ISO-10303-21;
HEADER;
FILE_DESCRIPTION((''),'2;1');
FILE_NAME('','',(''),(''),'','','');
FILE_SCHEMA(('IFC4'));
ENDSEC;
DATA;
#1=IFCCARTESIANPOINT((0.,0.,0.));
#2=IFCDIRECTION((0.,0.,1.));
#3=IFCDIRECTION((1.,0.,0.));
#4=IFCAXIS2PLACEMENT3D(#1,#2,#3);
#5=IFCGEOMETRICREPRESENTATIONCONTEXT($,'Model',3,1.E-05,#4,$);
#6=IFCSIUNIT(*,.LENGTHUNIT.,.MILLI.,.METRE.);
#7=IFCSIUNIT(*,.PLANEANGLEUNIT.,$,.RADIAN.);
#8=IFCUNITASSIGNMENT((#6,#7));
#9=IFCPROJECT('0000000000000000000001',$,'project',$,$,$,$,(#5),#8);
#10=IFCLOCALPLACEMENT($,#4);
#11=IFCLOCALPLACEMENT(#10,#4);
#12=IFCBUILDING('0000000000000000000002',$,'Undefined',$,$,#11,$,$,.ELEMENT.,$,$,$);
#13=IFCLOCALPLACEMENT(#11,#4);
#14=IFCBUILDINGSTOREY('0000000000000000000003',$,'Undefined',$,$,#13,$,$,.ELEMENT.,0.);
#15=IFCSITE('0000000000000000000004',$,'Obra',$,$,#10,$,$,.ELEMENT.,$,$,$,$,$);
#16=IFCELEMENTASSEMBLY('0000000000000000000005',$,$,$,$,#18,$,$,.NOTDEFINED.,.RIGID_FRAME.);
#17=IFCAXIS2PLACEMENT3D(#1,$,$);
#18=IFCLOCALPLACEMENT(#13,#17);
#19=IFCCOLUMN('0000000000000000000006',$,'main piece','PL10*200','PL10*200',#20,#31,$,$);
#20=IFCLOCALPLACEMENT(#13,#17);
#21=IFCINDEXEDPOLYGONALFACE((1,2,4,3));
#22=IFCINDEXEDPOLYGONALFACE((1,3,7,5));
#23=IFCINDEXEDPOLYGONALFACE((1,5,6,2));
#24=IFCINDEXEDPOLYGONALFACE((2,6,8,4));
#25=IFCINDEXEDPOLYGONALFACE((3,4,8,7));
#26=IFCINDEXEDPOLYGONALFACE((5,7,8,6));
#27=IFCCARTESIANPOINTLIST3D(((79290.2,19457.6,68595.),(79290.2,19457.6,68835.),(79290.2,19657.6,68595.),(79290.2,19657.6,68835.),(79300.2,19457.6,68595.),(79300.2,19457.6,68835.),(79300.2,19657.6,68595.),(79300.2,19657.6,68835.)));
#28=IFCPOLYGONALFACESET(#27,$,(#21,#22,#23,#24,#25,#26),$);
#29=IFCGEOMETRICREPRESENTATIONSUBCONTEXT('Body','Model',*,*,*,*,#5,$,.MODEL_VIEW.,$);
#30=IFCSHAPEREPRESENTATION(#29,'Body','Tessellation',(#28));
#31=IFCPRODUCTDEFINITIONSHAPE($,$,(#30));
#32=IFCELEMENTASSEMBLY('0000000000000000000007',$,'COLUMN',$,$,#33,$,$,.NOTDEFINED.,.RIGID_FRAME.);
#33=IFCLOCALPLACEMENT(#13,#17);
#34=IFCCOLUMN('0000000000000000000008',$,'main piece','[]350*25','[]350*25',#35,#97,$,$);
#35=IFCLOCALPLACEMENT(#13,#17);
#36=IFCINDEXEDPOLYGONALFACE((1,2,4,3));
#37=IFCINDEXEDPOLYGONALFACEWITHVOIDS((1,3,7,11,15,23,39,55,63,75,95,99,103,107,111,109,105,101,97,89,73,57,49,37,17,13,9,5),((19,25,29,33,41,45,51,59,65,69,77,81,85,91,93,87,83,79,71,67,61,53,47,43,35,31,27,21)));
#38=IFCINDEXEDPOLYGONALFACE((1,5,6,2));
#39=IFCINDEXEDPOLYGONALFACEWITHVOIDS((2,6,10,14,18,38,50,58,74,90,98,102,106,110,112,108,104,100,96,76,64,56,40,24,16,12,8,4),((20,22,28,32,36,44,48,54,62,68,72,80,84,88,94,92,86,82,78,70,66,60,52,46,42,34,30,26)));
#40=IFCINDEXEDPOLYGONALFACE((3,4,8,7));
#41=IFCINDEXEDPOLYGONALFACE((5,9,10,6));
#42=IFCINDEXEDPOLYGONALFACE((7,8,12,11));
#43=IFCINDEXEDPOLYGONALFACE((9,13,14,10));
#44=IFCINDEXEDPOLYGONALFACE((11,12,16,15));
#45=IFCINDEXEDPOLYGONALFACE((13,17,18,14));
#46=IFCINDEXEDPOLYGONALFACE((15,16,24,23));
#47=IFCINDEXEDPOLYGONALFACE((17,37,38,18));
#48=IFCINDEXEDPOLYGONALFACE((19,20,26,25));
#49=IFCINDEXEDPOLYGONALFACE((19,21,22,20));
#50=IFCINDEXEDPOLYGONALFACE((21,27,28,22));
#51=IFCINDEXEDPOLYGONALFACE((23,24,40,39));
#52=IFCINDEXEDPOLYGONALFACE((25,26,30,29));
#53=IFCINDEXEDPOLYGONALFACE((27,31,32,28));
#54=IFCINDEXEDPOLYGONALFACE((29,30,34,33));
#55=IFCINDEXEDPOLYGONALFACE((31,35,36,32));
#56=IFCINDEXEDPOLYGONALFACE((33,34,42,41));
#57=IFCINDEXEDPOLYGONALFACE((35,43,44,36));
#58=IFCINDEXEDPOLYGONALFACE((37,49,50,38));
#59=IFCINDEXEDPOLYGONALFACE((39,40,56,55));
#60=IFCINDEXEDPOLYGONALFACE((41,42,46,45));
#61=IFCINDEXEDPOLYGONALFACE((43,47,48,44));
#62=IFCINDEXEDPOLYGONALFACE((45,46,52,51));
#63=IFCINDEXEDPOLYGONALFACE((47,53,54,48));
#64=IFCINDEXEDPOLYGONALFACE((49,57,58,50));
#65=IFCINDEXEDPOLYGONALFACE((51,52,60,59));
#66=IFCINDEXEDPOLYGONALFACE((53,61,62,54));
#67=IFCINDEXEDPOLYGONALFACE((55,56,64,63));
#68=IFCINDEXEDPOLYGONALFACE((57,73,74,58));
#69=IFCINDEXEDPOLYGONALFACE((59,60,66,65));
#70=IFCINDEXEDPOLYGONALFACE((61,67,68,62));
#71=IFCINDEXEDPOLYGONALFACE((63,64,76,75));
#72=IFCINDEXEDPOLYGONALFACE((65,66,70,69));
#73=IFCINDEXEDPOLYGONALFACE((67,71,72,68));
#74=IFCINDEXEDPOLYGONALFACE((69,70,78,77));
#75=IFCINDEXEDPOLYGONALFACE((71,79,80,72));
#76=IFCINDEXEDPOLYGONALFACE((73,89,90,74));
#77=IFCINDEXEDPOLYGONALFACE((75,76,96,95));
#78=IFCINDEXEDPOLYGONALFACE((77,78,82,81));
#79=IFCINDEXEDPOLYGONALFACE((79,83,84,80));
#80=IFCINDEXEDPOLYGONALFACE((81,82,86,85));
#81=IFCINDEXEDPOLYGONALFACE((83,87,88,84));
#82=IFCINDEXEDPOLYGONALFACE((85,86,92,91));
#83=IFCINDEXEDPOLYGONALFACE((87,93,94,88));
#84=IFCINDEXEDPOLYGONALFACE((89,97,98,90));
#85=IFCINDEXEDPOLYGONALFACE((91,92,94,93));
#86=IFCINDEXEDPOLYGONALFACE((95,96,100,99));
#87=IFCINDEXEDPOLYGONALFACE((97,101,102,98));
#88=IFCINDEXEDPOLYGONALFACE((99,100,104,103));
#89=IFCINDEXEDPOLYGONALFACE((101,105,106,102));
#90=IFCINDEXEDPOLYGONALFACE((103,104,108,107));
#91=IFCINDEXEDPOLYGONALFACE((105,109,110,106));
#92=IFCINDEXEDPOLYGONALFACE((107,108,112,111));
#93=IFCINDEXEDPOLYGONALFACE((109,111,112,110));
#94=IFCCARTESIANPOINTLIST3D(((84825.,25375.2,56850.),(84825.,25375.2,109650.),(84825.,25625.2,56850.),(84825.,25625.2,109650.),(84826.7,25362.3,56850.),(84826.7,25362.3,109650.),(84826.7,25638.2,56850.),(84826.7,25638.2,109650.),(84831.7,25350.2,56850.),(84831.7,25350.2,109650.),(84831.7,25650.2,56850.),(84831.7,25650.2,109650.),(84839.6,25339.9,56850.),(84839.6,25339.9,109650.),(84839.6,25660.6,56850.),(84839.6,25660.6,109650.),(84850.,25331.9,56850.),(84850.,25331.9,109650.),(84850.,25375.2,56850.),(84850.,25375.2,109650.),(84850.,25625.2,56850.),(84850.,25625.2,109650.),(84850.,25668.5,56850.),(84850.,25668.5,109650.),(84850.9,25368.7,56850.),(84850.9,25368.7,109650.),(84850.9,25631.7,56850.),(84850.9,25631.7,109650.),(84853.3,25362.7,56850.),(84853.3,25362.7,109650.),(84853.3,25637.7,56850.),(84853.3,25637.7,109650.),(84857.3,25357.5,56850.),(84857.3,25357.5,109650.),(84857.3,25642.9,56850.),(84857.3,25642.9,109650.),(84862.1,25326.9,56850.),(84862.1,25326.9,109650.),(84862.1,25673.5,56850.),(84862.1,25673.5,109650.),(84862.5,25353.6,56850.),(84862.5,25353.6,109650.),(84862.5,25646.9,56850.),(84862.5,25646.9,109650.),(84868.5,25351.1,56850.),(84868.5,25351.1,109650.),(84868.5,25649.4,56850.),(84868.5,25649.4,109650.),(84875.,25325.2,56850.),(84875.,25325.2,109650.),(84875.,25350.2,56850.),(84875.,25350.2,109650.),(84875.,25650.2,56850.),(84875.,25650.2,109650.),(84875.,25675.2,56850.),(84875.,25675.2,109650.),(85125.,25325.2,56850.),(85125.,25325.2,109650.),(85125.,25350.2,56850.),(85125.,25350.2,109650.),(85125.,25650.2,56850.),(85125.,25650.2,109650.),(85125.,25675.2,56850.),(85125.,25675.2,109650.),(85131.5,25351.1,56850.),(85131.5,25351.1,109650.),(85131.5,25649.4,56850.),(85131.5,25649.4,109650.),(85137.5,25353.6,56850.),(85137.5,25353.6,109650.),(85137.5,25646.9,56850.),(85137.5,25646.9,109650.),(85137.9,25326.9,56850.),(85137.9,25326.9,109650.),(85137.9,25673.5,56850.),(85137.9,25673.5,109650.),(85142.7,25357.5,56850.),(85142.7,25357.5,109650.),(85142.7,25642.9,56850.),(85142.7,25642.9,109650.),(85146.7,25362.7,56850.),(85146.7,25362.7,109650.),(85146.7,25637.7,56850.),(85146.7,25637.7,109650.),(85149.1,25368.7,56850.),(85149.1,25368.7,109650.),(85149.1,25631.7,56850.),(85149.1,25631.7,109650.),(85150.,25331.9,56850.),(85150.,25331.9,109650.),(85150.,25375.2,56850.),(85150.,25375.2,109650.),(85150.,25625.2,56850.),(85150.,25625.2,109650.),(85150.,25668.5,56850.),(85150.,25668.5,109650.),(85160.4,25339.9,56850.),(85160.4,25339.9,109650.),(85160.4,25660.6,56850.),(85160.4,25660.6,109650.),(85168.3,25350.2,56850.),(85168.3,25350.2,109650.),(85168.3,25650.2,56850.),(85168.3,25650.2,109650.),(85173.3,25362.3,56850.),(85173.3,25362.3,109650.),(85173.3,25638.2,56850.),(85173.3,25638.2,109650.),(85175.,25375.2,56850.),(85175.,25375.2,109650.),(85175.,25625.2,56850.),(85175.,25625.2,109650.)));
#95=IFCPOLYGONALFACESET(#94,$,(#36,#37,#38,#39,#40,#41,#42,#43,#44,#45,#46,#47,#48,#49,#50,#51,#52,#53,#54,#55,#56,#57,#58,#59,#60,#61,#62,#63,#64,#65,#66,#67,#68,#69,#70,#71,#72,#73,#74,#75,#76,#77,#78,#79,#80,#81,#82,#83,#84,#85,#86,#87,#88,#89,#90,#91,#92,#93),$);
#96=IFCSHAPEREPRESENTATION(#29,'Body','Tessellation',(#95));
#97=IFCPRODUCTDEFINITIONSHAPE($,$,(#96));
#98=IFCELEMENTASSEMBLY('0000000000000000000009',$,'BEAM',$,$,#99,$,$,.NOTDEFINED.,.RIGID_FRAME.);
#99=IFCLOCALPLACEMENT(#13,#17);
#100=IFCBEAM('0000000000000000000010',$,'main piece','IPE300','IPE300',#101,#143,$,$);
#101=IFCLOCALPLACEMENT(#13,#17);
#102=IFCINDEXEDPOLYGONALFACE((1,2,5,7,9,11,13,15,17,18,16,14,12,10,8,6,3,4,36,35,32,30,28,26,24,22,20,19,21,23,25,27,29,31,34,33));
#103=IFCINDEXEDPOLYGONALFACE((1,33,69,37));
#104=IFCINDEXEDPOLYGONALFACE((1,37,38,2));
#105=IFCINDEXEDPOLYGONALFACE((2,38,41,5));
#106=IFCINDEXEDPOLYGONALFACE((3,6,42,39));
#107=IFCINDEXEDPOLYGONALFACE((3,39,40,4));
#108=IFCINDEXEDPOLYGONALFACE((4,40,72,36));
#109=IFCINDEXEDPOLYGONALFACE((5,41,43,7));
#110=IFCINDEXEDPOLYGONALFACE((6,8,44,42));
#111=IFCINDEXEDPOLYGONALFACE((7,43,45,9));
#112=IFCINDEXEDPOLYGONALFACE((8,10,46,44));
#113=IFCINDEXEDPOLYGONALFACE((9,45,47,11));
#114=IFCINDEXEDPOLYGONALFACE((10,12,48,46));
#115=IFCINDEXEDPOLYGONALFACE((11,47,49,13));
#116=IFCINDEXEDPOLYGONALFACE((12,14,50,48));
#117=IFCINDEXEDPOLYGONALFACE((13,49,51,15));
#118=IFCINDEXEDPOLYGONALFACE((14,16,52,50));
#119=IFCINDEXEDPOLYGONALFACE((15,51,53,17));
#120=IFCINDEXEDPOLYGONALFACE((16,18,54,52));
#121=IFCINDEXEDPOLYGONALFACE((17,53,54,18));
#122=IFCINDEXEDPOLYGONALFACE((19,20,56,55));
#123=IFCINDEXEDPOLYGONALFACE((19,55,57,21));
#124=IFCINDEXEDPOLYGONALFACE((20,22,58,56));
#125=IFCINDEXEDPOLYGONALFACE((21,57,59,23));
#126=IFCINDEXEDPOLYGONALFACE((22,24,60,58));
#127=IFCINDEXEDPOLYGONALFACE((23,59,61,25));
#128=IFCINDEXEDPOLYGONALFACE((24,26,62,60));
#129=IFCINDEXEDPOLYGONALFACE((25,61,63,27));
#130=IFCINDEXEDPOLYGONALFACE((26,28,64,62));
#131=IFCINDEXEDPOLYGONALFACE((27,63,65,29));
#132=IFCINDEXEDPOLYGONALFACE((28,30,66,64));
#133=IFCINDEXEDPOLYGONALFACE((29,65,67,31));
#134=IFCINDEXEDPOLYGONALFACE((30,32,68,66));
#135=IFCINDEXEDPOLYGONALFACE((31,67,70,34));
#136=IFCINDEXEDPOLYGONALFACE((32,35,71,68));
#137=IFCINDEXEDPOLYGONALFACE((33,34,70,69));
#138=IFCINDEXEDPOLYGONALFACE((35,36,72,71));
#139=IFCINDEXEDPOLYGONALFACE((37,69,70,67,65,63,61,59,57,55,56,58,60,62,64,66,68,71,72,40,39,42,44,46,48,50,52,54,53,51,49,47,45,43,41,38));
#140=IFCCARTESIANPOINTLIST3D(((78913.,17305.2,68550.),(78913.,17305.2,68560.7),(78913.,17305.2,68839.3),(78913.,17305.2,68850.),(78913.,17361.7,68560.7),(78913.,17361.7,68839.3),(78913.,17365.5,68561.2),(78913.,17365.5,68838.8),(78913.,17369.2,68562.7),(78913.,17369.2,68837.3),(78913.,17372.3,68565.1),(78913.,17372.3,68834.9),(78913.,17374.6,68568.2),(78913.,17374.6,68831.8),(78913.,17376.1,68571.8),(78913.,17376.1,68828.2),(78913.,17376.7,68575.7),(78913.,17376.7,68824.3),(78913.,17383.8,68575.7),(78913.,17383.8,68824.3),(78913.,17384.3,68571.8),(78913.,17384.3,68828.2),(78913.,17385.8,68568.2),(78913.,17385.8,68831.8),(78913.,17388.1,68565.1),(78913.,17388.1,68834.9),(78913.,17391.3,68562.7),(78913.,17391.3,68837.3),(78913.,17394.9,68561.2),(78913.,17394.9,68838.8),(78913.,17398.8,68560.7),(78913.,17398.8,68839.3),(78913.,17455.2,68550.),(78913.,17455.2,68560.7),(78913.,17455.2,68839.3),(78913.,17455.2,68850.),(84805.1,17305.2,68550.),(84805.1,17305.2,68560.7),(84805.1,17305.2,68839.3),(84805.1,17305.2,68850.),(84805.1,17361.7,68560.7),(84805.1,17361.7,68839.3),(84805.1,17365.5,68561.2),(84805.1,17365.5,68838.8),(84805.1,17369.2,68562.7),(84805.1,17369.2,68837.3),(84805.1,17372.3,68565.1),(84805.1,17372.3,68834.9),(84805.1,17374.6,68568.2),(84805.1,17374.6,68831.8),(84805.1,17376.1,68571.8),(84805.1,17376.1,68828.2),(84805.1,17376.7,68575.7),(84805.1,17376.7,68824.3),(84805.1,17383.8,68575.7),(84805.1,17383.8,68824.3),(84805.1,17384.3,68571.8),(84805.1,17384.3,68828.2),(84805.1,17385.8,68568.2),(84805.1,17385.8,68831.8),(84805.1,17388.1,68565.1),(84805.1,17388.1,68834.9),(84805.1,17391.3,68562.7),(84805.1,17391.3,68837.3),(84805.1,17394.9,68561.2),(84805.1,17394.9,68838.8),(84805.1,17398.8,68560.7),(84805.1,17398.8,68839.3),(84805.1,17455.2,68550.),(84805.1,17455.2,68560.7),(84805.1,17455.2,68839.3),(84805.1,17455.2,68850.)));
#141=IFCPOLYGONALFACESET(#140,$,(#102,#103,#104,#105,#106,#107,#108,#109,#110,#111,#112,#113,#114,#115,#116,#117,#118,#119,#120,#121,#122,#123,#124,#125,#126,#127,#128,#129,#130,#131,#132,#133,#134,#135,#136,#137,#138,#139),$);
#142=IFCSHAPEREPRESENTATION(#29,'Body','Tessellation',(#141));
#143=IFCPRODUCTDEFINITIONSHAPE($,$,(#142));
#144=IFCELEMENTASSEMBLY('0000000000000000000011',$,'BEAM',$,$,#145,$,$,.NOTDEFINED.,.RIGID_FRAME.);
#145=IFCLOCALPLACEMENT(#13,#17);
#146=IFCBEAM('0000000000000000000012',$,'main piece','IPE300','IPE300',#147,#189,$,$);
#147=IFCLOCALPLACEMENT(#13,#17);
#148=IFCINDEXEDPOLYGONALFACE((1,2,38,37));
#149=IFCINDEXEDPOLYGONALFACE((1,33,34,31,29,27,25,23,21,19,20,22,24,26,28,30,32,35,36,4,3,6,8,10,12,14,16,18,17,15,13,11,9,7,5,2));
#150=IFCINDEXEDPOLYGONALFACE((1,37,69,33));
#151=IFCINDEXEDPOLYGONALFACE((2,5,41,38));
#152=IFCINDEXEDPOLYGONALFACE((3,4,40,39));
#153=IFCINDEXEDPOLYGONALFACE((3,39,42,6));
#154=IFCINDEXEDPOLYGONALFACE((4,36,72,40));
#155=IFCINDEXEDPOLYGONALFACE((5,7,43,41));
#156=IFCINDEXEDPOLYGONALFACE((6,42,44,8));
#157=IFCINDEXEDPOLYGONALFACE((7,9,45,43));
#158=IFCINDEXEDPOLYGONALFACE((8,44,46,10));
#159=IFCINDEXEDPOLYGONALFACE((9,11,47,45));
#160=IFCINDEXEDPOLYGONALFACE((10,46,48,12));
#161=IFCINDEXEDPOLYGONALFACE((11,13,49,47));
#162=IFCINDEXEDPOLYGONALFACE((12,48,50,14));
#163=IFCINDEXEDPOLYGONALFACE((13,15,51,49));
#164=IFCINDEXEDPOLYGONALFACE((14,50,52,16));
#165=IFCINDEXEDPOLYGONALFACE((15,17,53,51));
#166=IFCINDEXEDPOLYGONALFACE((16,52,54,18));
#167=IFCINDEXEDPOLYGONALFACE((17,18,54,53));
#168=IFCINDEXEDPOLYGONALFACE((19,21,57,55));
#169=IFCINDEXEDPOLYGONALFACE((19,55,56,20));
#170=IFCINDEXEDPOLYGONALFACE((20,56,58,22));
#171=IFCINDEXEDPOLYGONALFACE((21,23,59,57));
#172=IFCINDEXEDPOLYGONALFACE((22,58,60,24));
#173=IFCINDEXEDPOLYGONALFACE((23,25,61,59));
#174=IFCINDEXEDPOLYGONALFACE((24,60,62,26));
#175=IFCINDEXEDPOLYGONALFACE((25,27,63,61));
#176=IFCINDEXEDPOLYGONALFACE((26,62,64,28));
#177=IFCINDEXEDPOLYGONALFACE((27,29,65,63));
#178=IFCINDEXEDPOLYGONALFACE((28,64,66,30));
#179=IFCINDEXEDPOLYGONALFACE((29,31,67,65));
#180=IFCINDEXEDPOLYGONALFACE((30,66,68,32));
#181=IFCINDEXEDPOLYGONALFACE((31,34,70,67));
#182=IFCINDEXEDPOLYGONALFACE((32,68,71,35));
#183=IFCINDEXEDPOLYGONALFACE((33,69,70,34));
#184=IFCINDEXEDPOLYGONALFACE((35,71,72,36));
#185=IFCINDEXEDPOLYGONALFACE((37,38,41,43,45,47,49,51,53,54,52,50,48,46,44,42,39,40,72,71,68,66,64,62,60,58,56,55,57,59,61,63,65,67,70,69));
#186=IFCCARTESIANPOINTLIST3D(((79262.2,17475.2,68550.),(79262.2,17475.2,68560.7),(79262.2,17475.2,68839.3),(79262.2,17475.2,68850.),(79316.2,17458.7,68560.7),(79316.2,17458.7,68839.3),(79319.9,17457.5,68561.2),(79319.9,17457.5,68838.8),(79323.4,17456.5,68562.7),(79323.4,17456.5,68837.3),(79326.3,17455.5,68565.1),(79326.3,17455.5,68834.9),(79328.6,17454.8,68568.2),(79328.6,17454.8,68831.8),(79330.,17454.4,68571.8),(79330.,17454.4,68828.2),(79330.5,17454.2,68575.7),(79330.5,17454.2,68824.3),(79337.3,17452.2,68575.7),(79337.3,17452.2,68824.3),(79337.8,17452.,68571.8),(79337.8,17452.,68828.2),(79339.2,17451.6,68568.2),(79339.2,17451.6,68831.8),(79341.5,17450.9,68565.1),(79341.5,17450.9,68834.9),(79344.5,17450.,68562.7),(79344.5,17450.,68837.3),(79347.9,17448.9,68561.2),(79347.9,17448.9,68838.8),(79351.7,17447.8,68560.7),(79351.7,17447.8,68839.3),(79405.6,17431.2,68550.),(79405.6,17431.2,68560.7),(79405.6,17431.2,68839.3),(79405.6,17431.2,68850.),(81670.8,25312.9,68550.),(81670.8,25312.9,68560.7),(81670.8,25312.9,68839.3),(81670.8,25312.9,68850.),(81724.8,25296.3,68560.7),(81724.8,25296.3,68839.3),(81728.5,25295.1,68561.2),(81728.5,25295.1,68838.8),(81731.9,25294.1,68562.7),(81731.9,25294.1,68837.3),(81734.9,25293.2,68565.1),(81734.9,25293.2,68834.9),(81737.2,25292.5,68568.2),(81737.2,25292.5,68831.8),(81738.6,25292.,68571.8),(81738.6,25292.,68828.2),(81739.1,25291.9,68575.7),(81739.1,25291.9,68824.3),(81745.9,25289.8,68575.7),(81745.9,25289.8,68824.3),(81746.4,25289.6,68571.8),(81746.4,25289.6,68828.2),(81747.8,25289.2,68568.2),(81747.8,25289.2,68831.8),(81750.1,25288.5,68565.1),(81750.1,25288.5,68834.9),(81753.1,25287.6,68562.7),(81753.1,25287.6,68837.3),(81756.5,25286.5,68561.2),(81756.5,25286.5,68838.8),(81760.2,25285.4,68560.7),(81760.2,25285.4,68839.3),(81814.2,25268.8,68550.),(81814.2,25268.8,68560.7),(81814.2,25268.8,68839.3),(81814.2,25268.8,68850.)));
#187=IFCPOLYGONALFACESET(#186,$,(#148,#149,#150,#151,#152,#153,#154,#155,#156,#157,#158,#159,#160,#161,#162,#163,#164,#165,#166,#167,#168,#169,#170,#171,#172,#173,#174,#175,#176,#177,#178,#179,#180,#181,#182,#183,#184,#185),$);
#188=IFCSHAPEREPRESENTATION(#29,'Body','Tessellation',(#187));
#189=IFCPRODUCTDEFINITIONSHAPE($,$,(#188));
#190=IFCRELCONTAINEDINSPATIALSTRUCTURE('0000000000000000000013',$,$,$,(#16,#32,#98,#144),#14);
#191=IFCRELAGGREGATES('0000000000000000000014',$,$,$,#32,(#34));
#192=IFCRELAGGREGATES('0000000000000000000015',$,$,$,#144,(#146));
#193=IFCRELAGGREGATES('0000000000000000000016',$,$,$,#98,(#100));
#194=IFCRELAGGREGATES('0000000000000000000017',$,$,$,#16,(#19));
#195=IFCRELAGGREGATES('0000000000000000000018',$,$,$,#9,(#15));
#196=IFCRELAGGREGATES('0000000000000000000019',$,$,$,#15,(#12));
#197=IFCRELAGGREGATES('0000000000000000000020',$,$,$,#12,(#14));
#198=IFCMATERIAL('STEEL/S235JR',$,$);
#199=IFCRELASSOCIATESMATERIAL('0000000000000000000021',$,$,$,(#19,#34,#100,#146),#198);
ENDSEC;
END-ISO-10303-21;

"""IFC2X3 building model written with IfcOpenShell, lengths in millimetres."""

from ifc_helpers import new_model, si_unit, frame, origin_with_axes, origin_2d_with_axis, place, context, subcontext, project, spatial, rectangle, hollow_rectangle, i_section, extrude, material, element, aggregate, save


model = new_model("IFC2X3")

# Units and contexts
model_context = context("Model", 3, precision=1e-05, world=origin_with_axes())
body_context = subcontext(model_context, "Body", "Model", "MODEL_VIEW")
ifc_project = project(units=[si_unit("LENGTHUNIT", "METRE", prefix="MILLI"), si_unit("PLANEANGLEUNIT", "RADIAN")], contexts=[model_context])

# Site, building, storey
site_placement = place(None, origin_with_axes())
site = spatial("IfcSite", under=ifc_project, at=site_placement, Name="Obra", CompositionType="ELEMENT")
building_placement = place(site_placement, origin_with_axes())
building = spatial("IfcBuilding", under=site, at=building_placement, Name="Undefined", CompositionType="ELEMENT")
storey_placement = place(building_placement, origin_with_axes())
storey = spatial("IfcBuildingStorey", under=building, at=storey_placement, Name="Undefined", CompositionType="ELEMENT", Elevation=0.0)

# Element assemblies, columns
assembly_1_placement = place(storey_placement, origin_with_axes())
assembly_1 = element("IfcElementAssembly", 1, at=assembly_1_placement, inside=storey, AssemblyPlace="NOTDEFINED", PredefinedType="RIGID_FRAME")
ifc_material = material(Name="STEEL/S235JR")
column_1_placement = place(assembly_1_placement, frame((79295.2, 19557.6, 68595.0), z_axis=(0.0, 0.0, 1.0), x_axis=(0.0, -1.0, 0.0)))
column_1 = element("IfcColumn", 2, at=column_1_placement, material=ifc_material, Name="main piece", Description="PL10*200", ObjectType="PL10*200", context=body_context, shape_type="SweptSolid", body=[
    extrude(rectangle(XDim=10.0, YDim=200.0, at=origin_2d_with_axis()), frame((0.0, 0.0, 240.0), z_axis=(0.0, 0.0, -1.0), x_axis=(0.0, 1.0, 0.0)), (0.0, 0.0, 1.0), 240.0),
])
assembly_2_placement = place(storey_placement, origin_with_axes())
assembly_2 = element("IfcElementAssembly", 3, at=assembly_2_placement, inside=storey, Name="COLUMN", AssemblyPlace="NOTDEFINED", PredefinedType="RIGID_FRAME")
column_2_placement = place(assembly_2_placement, frame((85000.0, 25500.2, 56850.0), z_axis=(0.0, 0.0, 1.0), x_axis=(0.0, 1.0, 0.0)))
column_2 = element("IfcColumn", 4, at=column_2_placement, material=ifc_material, Name="main piece", Description="[]350*25", ObjectType="[]350*25", context=body_context, shape_type="SweptSolid", body=[
    extrude(hollow_rectangle(XDim=350.0, YDim=350.0, WallThickness=25.0, InnerFilletRadius=25.0, OuterFilletRadius=50.0, at=origin_2d_with_axis()), frame((0.0, 0.0, 52800.0), z_axis=(0.0, 0.0, -1.0), x_axis=(0.0, 1.0, 0.0)), (0.0, 0.0, 1.0), 52800.0),
])
aggregate(assembly_2, [column_2])

# Element assemblies, beams
assembly_3_placement = place(storey_placement, origin_with_axes())
assembly_3 = element("IfcElementAssembly", 5, at=assembly_3_placement, inside=storey, Name="BEAM", AssemblyPlace="NOTDEFINED", PredefinedType="RIGID_FRAME")
beam_1_placement = place(assembly_3_placement, frame((78913.0, 17380.2, 68700.0), z_axis=(0.0, 0.0, 1.0), x_axis=(1.0, 0.0, 0.0)))
beam_1 = element("IfcBeam", 6, at=beam_1_placement, material=ifc_material, Name="main piece", Description="IPE300", ObjectType="IPE300", context=body_context, shape_type="SweptSolid", body=[
    extrude(i_section(OverallWidth=150.0, OverallDepth=300.0, WebThickness=7.1, FlangeThickness=10.7, FilletRadius=15.0, at=origin_2d_with_axis()), frame((5892.1, 0.0, 0.0), z_axis=(-1.0, 0.0, 0.0), x_axis=(0.0, -1.0, 0.0)), (0.0, 0.0, 1.0), 5892.1),
])
assembly_4_placement = place(storey_placement, origin_with_axes())
assembly_4 = element("IfcElementAssembly", 7, at=assembly_4_placement, inside=storey, Name="BEAM", AssemblyPlace="NOTDEFINED", PredefinedType="RIGID_FRAME")
beam_2_placement = place(assembly_4_placement, frame((79333.9, 17453.2, 68700.0), z_axis=(0.0, 0.0, 1.0), x_axis=(0.293752, 0.955882, 0.0)))
beam_2 = element("IfcBeam", 8, at=beam_2_placement, material=ifc_material, Name="main piece", Description="IPE300", ObjectType="IPE300", context=body_context, shape_type="SweptSolid", body=[
    extrude(i_section(OverallWidth=150.0, OverallDepth=300.0, WebThickness=7.1, FlangeThickness=10.7, FilletRadius=15.0, at=origin_2d_with_axis()), frame((8199.4, 0.0, 0.0), z_axis=(-1.0, 0.0, 0.0), x_axis=(0.0, -1.0, 0.0)), (0.0, 0.0, 1.0), 8199.4),
])
aggregate(assembly_4, [beam_2])

aggregate(assembly_3, [beam_1])
aggregate(assembly_1, [column_1])

save(model, "model.ifc")
